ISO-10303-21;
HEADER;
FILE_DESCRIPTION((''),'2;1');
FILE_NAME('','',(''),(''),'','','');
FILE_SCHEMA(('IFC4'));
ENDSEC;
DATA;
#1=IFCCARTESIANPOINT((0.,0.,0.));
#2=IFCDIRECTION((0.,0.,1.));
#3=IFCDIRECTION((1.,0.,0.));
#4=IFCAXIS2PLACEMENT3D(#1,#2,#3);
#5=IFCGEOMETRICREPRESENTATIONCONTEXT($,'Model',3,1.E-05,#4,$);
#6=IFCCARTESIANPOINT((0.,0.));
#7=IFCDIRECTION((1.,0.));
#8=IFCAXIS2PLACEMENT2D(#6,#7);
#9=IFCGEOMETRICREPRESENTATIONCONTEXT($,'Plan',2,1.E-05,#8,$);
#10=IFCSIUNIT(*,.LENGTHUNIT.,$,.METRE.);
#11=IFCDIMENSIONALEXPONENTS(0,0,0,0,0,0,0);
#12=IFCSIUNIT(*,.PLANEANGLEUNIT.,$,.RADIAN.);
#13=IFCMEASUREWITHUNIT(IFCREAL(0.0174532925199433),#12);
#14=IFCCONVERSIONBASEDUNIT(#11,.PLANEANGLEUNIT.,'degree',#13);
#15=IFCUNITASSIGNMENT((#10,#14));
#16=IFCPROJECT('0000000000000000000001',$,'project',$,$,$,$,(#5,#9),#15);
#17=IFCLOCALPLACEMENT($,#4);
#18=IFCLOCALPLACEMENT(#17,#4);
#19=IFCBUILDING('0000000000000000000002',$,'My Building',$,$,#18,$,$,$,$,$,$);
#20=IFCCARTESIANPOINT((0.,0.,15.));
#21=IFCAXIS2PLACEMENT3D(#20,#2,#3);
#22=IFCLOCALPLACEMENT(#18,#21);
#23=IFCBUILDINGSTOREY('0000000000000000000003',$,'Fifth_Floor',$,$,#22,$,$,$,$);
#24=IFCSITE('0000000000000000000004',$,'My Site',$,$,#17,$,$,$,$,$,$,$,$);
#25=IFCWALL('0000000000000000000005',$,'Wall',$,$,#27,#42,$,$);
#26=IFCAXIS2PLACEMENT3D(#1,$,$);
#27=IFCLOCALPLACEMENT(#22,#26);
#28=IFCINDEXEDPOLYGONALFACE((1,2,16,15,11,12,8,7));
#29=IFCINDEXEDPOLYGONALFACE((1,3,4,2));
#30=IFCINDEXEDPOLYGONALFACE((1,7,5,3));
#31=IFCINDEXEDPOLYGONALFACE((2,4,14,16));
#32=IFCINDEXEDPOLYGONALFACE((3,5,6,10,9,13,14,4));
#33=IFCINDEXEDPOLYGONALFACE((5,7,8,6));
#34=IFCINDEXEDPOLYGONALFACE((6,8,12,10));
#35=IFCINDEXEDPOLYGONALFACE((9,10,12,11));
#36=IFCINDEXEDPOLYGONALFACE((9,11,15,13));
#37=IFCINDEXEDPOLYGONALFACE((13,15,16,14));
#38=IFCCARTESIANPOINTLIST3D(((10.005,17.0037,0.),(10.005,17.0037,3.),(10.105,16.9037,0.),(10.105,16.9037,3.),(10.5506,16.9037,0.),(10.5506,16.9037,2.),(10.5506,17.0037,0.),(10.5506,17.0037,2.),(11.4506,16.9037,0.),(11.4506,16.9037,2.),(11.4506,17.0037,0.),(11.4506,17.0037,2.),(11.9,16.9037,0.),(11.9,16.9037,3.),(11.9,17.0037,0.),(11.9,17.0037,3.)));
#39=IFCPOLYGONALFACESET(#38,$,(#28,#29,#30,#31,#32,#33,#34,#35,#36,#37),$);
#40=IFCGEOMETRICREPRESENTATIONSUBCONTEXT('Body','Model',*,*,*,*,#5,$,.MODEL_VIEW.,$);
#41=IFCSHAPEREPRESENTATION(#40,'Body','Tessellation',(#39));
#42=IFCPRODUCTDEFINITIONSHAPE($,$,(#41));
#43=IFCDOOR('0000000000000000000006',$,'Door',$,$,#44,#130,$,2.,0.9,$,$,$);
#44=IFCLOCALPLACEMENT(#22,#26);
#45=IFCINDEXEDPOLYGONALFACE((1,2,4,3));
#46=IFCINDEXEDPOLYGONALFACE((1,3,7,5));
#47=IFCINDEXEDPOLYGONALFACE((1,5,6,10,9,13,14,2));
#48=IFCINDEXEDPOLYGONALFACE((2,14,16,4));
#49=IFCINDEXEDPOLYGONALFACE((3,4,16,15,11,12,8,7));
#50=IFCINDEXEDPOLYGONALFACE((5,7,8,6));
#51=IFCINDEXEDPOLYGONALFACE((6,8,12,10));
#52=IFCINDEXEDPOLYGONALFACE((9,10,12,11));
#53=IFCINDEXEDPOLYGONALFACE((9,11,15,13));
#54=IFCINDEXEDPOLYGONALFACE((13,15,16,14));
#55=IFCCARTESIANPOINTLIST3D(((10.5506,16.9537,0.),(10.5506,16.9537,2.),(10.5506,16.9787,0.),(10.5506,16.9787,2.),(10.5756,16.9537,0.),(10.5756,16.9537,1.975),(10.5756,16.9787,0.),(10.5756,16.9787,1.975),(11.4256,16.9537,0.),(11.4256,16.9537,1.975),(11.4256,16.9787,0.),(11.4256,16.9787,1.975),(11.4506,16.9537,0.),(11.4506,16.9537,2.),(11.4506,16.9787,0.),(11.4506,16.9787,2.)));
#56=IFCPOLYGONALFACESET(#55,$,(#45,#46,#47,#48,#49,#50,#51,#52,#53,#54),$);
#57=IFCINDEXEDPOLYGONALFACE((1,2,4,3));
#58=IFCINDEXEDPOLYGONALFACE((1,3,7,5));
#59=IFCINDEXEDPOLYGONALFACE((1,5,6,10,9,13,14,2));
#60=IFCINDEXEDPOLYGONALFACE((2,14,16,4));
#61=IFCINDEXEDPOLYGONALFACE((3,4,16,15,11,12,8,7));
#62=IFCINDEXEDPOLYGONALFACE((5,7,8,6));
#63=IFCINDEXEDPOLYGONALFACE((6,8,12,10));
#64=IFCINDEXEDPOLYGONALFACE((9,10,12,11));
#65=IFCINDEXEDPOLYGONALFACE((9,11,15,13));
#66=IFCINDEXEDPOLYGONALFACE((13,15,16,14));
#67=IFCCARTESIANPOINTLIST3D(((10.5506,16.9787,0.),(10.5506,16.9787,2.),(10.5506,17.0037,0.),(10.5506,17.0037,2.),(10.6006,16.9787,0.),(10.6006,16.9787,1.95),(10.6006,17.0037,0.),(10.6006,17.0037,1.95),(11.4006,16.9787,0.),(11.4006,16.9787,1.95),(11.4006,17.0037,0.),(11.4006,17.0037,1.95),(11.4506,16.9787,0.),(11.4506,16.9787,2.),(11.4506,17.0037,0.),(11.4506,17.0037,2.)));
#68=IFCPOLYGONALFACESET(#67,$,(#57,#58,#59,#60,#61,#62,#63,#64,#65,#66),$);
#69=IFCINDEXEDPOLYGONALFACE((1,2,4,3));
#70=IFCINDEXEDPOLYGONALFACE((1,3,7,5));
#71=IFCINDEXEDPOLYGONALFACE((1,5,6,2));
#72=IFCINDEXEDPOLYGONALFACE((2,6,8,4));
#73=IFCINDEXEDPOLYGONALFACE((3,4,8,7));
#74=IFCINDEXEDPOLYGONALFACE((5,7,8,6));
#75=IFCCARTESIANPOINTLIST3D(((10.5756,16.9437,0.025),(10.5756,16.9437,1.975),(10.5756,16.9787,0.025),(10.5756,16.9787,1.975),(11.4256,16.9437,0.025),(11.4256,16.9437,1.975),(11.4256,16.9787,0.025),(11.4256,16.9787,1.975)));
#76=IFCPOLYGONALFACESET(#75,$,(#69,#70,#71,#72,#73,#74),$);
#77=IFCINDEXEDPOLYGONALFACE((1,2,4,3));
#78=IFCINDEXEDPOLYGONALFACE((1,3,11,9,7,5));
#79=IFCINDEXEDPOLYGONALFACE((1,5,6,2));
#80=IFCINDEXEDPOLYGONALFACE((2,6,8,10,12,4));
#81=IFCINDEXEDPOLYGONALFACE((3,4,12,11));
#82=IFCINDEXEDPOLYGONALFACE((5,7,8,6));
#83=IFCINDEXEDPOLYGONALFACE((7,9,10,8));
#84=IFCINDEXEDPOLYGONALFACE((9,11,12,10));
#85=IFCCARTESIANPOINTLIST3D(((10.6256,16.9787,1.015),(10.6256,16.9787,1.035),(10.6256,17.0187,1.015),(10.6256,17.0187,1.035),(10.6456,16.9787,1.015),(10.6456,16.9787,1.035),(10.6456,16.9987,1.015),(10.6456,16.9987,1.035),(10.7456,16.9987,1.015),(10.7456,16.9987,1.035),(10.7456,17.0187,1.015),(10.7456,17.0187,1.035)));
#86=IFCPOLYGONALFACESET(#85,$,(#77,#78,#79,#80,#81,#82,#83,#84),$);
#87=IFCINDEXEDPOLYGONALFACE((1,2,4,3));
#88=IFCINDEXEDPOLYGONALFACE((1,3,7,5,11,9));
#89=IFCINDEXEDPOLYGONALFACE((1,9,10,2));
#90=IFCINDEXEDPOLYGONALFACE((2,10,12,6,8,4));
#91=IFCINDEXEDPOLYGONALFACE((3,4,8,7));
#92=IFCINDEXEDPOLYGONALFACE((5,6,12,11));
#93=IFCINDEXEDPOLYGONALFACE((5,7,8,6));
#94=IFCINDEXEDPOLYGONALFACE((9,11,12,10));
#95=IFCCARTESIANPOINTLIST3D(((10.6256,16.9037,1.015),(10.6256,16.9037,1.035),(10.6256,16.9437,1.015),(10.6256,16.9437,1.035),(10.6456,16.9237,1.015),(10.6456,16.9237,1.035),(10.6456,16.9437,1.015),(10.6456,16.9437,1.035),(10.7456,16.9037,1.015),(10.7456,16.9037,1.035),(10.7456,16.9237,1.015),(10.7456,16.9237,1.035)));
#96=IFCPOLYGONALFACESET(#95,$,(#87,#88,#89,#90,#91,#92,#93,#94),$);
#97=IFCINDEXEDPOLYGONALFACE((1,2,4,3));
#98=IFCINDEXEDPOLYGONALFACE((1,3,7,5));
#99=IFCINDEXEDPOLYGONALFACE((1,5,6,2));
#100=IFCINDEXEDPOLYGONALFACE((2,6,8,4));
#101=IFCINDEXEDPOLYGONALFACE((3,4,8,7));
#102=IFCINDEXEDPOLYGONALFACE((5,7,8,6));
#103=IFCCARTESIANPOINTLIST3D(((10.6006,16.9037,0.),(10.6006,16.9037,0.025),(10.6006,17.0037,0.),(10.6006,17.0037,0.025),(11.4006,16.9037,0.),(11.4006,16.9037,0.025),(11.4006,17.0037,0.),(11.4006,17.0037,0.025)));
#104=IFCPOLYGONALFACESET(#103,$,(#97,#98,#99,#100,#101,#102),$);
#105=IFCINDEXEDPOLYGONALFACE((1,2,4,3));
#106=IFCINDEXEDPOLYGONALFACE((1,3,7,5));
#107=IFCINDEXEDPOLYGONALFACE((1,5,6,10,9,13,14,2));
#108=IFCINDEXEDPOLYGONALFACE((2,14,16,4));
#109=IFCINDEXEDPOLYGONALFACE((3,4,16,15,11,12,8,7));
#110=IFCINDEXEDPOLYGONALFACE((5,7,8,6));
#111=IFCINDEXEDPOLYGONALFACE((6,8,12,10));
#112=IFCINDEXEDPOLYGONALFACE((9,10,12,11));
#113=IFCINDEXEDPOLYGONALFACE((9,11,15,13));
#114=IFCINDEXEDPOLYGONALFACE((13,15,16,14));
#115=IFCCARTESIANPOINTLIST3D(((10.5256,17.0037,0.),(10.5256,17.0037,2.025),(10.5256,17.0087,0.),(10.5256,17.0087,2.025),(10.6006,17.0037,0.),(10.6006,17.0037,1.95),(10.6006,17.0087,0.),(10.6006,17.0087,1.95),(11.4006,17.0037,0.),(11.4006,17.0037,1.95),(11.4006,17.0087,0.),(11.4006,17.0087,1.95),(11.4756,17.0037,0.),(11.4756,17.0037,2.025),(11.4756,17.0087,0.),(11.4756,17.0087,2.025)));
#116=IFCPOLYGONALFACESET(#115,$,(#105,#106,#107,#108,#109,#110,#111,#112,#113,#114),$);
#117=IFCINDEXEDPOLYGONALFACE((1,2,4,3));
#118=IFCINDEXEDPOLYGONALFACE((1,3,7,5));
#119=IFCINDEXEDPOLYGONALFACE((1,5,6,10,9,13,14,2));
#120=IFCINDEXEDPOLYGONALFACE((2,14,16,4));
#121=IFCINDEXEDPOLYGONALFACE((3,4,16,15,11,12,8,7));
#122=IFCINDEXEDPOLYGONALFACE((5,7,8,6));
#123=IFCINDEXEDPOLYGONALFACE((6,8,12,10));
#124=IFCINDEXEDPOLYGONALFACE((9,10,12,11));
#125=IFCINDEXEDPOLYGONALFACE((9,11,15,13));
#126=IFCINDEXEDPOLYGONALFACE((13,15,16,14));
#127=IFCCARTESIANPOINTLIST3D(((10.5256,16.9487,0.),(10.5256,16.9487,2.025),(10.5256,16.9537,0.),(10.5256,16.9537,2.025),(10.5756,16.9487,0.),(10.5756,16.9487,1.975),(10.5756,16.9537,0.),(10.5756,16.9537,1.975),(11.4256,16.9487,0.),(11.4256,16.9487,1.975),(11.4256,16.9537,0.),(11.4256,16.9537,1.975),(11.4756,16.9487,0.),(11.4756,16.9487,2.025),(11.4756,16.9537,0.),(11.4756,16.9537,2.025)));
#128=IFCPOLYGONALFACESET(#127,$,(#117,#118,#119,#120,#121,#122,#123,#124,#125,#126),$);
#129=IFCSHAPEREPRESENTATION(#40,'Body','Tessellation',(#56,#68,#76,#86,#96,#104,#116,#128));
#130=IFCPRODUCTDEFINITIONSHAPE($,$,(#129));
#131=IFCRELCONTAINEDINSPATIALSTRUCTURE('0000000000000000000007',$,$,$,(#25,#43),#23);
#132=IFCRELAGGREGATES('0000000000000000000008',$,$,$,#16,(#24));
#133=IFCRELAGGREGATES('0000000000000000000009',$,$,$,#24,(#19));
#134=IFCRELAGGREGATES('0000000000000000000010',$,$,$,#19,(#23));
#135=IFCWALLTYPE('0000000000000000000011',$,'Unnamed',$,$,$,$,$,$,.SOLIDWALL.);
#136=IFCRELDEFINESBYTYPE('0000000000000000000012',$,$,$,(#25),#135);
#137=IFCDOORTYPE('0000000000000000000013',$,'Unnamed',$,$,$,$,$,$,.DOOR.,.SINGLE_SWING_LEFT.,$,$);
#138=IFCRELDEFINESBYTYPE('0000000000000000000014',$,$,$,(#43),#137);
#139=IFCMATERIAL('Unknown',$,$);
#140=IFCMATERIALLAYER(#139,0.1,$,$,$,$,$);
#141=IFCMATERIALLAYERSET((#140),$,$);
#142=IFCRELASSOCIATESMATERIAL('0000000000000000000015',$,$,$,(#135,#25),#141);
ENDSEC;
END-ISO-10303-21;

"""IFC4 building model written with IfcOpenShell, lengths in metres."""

from ifc_helpers import new_model, entity, si_unit, converted_unit, frame, origin_with_axes, origin_2d_with_axis, place, context, subcontext, project, spatial, line, indexed_curve, outline, extrude, shape, source, transform, mapped, material, layer, layer_set, layer_usage, type_object, type_shapes, element, fill, save


model = new_model("IFC4")

# Units and contexts
model_context = context("Model", 3, precision=1e-05, world=origin_with_axes())
plan_context = context("Plan", 2, precision=1e-05, world=origin_2d_with_axis())
body_context_1 = subcontext(model_context, "Body", "Model", "MODEL_VIEW")
body_context_2 = subcontext(plan_context, "Body", "Plan", "PLAN_VIEW")
ifc_project = project(units=[si_unit("LENGTHUNIT", "METRE"), converted_unit("PLANEANGLEUNIT", "degree", entity("IfcReal", 0.0174532925199433), si_unit("PLANEANGLEUNIT", "RADIAN"), dimensions=[0, 0, 0, 0, 0, 0, 0])], contexts=[model_context, plan_context])

# Site, building, storey
site_placement = place(None, origin_with_axes())
site = spatial("IfcSite", under=ifc_project, at=site_placement, Name="My Site")
building_placement = place(site_placement, origin_with_axes())
building = spatial("IfcBuilding", under=site, at=building_placement, Name="My Building")
storey_placement = place(building_placement, frame((0.0, 0.0, 15.0), z_axis=(0.0, 0.0, 1.0), x_axis=(1.0, 0.0, 0.0)))
storey = spatial("IfcBuildingStorey", under=building, at=storey_placement, Name="Fifth_Floor")

# Shared definitions
ifc_material = material(Name="Unknown")
ifc_layer = layer(ifc_material, 0.1)
ifc_layer_set = layer_set([ifc_layer])
wall_type = type_object("IfcWallType", Name="Unnamed", PredefinedType="SOLIDWALL", material=ifc_layer_set)

# Wall, opening, door
shared_shape_1 = source(origin_with_axes(), body_context_1, "Body", "SweptSolid", [
    extrude(outline(indexed_curve([(0.0, 0.0), (0.9, 0.0), (0.9, 2.0), (0.0, 2.0)], segments=[line(1, 2, 3, 4, 1)])), frame((0.0, -0.6, 0.0), z_axis=(0.0, -1.0, 0.0), x_axis=(1.0, 0.0, 0.0)), (0.0, 0.0, -1.0), 1.2),
])
door_type = type_object("IfcDoorType", Name="Unnamed", OperationType="SINGLE_SWING_LEFT", PredefinedType="DOOR")
shared_shape_2 = source(origin_with_axes(), body_context_1, "Body", "SweptSolid", [
    extrude(outline(indexed_curve([(0.0, 0.0), (0.0, 2.0), (0.9, 2.0), (0.9, 0.0), (0.875, 0.0), (0.875, 1.975), (0.025, 1.975), (0.025, 0.0)], segments=[line(1, 2, 3, 4, 5, 6, 7, 8, 1)])), frame((0.0, 0.025, 0.0), z_axis=(0.0, -1.0, 0.0), x_axis=(1.0, 0.0, 0.0)), (0.0, 0.0, -1.0), 0.025),
    extrude(outline(indexed_curve([(0.0, 0.0), (0.0, 2.0), (0.9, 2.0), (0.9, 0.0), (0.85, 0.0), (0.85, 1.95), (0.05, 1.95), (0.05, 0.0)], segments=[line(1, 2, 3, 4, 5, 6, 7, 8, 1)])), frame((0.0, 0.0, 0.0), z_axis=(0.0, -1.0, 0.0), x_axis=(1.0, 0.0, 0.0)), (0.0, 0.0, -1.0), 0.025),
    extrude(outline(indexed_curve([(0.0, 0.0), (0.85, 0.0), (0.85, 0.035), (0.0, 0.035)], segments=[line(1, 2, 3, 4, 1)])), frame((0.025, 0.025, 0.025), z_axis=(0.0, 0.0, 1.0), x_axis=(1.0, 0.0, 0.0)), (0.0, 0.0, 1.0), 1.95),
    extrude(outline(indexed_curve([(0.0, 0.0), (0.0, -0.04), (-0.12, -0.04), (-0.12, -0.02), (-0.02, -0.02), (-0.02, 0.0)], segments=[line(1, 2, 3, 4, 5, 6, 1)])), frame((0.825, 0.025, 1.015), z_axis=(0.0, 0.0, 1.0), x_axis=(1.0, 0.0, 0.0)), (0.0, 0.0, 1.0), 0.02),
    extrude(outline(indexed_curve([(0.0, 0.0), (0.0, 0.04), (-0.12, 0.04), (-0.12, 0.02), (-0.02, 0.02), (-0.02, 0.0)], segments=[line(1, 2, 3, 4, 5, 6, 1)])), frame((0.825, 0.06, 1.015), z_axis=(0.0, 0.0, 1.0), x_axis=(1.0, 0.0, 0.0)), (0.0, 0.0, 1.0), 0.02),
    extrude(outline(indexed_curve([(0.0, 0.0), (0.8, 0.0), (0.8, 0.1), (0.0, 0.1)], segments=[line(1, 2, 3, 4, 1)])), frame((0.05, 0.0, 0.0), z_axis=(0.0, 0.0, 1.0), x_axis=(1.0, 0.0, 0.0)), (0.0, 0.0, 1.0), 0.025),
    extrude(outline(indexed_curve([(0.0, 0.0), (0.0, 2.025), (0.95, 2.025), (0.95, 0.0), (0.875, 0.0), (0.875, 1.95), (0.075, 1.95), (0.075, 0.0)], segments=[line(1, 2, 3, 4, 5, 6, 7, 8, 1)])), frame((-0.025, -0.005, 0.0), z_axis=(0.0, -1.0, 0.0), x_axis=(1.0, 0.0, 0.0)), (0.0, 0.0, -1.0), 0.005),
    extrude(outline(indexed_curve([(0.0, 0.0), (0.0, 2.025), (0.95, 2.025), (0.95, 0.0), (0.9, 0.0), (0.9, 1.975), (0.05, 1.975), (0.05, 0.0)], segments=[line(1, 2, 3, 4, 5, 6, 7, 8, 1)])), frame((-0.025, 0.05, 0.0), z_axis=(0.0, -1.0, 0.0), x_axis=(1.0, 0.0, 0.0)), (0.0, 0.0, -1.0), 0.005),
])
shared_shape_3 = source(origin_with_axes(), body_context_2, "Body", "Curve2D", [
    entity("IfcIndexedPolyCurve", entity("IfcCartesianPointList2D", [[0.0, 0.0], [0.0, 0.05], [0.025, 0.05], [0.025, 0.025], [0.05, 0.025], [0.05, 0.0]]), [entity("IfcLineIndex", [1, 2, 3, 4, 5, 6, 1])]),
    entity("IfcIndexedPolyCurve", entity("IfcCartesianPointList2D", [[0.9, 0.0], [0.9, 0.05], [0.875, 0.05], [0.875, 0.025], [0.85, 0.025], [0.85, 0.0]]), [entity("IfcLineIndex", [1, 2, 3, 4, 5, 6, 1])]),
    entity("IfcTrimmedCurve", entity("IfcEllipse", entity("IfcAxis2Placement2D", entity("IfcCartesianPoint", [0.06, 0.05]), entity("IfcDirection", [1.0, 0.0])), 0.815, 0.85), [entity("IfcCartesianPoint", [0.875, 0.05])], [entity("IfcCartesianPoint", [0.06, 0.9])], True, "CARTESIAN"),
    entity("IfcIndexedPolyCurve", entity("IfcCartesianPointList2D", [[0.025, 0.05], [0.06, 0.05], [0.06, 0.9], [0.025, 0.9]]), [entity("IfcLineIndex", [1, 2, 3, 4, 1])]),
])
type_shapes(door_type, [shared_shape_2, shared_shape_3])
ifc_layer_usage_1 = layer_usage(ifc_layer_set, "AXIS2", "POSITIVE", 0.0)
wall_1_placement = place(storey_placement, frame((11.9, 17.0037, 0.0), z_axis=(0.0, 0.0, 1.0), x_axis=(-1.0, 0.0, 0.0)))
wall_1 = element("IfcWall", 1, at=wall_1_placement, inside=storey, type_object=wall_type, material=ifc_layer_usage_1, Name="Wall", context=body_context_1, shape_type="SweptSolid", body=[
    extrude(outline(indexed_curve([(0.0, 0.0), (0.0, 0.1), (1.795, 0.1), (1.895, 0.0)], segments=[line(1, 2, 3, 4, 1)])), origin_with_axes(), (0.0, 0.0, 1.0), 3.0),
])
opening_1_placement = place(wall_1_placement, frame((0.4494, 0.0, 0.0), z_axis=(0.0, 0.0, 1.0), x_axis=(1.0, 0.0, 0.0)))
opening_1 = element("IfcOpeningElement", 2, at=opening_1_placement, cuts=wall_1, PredefinedType="OPENING", context=body_context_1, shape_type="MappedRepresentation", body=[
    mapped(shared_shape_1, transform((0.0, 0.0, 0.0), x_axis=(1.0, 0.0, 0.0), y_axis=(0.0, 1.0, 0.0), z_axis=(0.0, 0.0, 1.0), scale=1.0)),
])
door_1_placement = place(opening_1_placement, origin_with_axes())
door_1 = element("IfcDoor", 3, at=door_1_placement, inside=storey, type_object=door_type, Name="Door", OverallHeight=2.0, OverallWidth=0.9, shapes=[
    shape(body_context_1, "Body", "MappedRepresentation", [mapped(shared_shape_2, transform((0.0, 0.0, 0.0), x_axis=(1.0, 0.0, 0.0), y_axis=(0.0, 1.0, 0.0), z_axis=(0.0, 0.0, 1.0), scale=1.0))]),
    shape(body_context_2, "Body", "MappedRepresentation", [mapped(shared_shape_3, transform((0.0, 0.0, 0.0), x_axis=(1.0, 0.0, 0.0), y_axis=(0.0, 1.0, 0.0), z_axis=(0.0, 0.0, 1.0), scale=1.0))]),
])
fill(opening_1, door_1)

save(model, "model.ifc")
